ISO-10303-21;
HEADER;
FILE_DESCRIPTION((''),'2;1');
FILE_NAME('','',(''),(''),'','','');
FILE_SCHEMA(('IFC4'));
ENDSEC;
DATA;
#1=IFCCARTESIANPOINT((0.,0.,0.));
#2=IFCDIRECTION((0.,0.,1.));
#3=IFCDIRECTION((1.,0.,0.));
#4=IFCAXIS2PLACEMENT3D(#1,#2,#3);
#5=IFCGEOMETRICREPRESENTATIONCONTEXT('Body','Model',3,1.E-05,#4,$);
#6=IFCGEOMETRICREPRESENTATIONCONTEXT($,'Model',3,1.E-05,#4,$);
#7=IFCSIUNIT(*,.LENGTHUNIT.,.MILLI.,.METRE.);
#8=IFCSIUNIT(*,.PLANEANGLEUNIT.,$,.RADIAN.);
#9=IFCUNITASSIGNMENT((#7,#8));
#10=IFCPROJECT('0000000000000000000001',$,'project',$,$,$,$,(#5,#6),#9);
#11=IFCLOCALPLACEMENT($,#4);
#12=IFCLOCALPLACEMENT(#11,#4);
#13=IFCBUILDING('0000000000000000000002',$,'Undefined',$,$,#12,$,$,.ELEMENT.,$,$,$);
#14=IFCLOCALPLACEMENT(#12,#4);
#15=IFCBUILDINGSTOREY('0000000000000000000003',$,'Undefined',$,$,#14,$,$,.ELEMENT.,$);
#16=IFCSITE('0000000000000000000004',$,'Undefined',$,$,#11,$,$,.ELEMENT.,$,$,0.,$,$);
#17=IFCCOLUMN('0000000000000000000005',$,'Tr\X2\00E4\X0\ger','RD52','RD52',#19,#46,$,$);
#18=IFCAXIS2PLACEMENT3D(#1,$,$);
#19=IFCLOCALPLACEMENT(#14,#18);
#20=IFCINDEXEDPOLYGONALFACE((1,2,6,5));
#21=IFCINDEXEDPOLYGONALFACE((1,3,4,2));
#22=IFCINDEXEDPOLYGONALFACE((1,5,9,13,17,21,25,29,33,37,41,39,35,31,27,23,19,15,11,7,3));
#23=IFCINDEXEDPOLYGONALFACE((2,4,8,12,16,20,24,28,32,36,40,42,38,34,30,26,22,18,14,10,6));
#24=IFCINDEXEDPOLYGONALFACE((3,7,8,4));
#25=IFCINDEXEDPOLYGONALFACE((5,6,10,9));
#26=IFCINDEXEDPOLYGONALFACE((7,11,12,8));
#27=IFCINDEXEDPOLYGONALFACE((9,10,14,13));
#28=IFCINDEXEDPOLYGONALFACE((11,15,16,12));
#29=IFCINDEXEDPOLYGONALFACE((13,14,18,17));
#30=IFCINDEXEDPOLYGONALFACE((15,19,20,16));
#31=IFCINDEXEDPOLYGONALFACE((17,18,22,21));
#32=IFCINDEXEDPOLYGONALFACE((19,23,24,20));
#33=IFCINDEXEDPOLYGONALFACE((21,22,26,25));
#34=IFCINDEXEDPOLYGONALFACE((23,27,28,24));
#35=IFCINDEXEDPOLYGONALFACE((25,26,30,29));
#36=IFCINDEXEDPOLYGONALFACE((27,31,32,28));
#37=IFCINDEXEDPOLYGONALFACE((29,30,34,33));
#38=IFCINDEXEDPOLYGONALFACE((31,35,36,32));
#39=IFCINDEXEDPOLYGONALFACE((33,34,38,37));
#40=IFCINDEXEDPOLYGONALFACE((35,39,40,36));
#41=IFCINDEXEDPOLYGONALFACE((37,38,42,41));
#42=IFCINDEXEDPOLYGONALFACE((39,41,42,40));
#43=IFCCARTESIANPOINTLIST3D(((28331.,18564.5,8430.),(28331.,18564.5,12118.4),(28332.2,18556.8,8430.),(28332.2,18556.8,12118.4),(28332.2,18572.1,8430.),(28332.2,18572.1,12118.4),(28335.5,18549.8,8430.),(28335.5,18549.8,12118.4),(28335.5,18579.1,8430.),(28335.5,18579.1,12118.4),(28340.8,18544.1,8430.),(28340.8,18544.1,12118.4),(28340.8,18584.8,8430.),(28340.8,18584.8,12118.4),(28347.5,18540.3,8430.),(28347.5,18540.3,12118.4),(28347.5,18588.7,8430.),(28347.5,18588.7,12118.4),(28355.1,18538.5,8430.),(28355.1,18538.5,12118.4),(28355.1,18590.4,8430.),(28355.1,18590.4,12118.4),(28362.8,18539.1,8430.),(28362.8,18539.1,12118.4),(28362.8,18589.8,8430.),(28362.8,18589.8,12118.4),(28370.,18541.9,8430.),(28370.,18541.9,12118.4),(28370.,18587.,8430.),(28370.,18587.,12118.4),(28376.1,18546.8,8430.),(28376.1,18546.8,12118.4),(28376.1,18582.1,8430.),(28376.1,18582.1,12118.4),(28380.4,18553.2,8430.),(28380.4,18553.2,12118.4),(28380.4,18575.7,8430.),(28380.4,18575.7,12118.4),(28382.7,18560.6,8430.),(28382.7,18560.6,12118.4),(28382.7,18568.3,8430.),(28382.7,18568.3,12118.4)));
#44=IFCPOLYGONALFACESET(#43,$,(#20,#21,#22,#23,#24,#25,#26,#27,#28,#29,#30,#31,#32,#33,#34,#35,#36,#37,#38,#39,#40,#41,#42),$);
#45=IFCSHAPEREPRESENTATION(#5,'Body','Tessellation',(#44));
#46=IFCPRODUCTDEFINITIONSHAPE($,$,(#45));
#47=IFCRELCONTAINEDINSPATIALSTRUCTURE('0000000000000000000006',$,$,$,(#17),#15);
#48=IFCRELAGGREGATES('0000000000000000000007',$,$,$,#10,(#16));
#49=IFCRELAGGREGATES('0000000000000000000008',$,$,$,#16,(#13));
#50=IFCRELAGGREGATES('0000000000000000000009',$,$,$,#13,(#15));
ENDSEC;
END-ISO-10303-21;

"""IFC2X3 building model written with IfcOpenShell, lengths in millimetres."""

from ifc_helpers import new_model, si_unit, frame, origin_with_axes, origin_2d_with_axis, place, context, project, spatial, circle, extrude, element, save


model = new_model("IFC2X3")

# Units and contexts
model_context_1 = context("Model", 3, precision=1e-05, world=origin_with_axes(), identifier="Body")
model_context_2 = context("Model", 3, precision=1e-05, world=origin_with_axes())
ifc_project = project(units=[si_unit("LENGTHUNIT", "METRE", prefix="MILLI"), si_unit("PLANEANGLEUNIT", "RADIAN")], contexts=[model_context_1, model_context_2])

# Site, building, storey
site_placement = place(None, origin_with_axes())
site = spatial("IfcSite", under=ifc_project, at=site_placement, Name="Undefined", CompositionType="ELEMENT", RefElevation=0.0)
building_placement = place(site_placement, origin_with_axes())
building = spatial("IfcBuilding", under=site, at=building_placement, Name="Undefined", CompositionType="ELEMENT")
storey_placement = place(building_placement, origin_with_axes())
storey = spatial("IfcBuildingStorey", under=building, at=storey_placement, Name="Undefined", CompositionType="ELEMENT")

# Column
column_1_placement = place(storey_placement, frame((28357.0, 18564.5, 8430.0), z_axis=(0.0, 0.0, 1.0), x_axis=(1.0, 0.0, 0.0)))
element("IfcColumn", 1, at=column_1_placement, inside=storey, Name="Träger", Description="RD52", ObjectType="RD52", context=model_context_1, shape_type="SweptSolid", body=[
    extrude(circle(Radius=26.0, at=origin_2d_with_axis()), frame((0.0, 0.0, 3688.4), z_axis=(0.0, 0.0, -1.0), x_axis=(0.5, 0.866025, 0.0)), (0.0, 0.0, 1.0), 3688.4),
])

save(model, "model.ifc")
